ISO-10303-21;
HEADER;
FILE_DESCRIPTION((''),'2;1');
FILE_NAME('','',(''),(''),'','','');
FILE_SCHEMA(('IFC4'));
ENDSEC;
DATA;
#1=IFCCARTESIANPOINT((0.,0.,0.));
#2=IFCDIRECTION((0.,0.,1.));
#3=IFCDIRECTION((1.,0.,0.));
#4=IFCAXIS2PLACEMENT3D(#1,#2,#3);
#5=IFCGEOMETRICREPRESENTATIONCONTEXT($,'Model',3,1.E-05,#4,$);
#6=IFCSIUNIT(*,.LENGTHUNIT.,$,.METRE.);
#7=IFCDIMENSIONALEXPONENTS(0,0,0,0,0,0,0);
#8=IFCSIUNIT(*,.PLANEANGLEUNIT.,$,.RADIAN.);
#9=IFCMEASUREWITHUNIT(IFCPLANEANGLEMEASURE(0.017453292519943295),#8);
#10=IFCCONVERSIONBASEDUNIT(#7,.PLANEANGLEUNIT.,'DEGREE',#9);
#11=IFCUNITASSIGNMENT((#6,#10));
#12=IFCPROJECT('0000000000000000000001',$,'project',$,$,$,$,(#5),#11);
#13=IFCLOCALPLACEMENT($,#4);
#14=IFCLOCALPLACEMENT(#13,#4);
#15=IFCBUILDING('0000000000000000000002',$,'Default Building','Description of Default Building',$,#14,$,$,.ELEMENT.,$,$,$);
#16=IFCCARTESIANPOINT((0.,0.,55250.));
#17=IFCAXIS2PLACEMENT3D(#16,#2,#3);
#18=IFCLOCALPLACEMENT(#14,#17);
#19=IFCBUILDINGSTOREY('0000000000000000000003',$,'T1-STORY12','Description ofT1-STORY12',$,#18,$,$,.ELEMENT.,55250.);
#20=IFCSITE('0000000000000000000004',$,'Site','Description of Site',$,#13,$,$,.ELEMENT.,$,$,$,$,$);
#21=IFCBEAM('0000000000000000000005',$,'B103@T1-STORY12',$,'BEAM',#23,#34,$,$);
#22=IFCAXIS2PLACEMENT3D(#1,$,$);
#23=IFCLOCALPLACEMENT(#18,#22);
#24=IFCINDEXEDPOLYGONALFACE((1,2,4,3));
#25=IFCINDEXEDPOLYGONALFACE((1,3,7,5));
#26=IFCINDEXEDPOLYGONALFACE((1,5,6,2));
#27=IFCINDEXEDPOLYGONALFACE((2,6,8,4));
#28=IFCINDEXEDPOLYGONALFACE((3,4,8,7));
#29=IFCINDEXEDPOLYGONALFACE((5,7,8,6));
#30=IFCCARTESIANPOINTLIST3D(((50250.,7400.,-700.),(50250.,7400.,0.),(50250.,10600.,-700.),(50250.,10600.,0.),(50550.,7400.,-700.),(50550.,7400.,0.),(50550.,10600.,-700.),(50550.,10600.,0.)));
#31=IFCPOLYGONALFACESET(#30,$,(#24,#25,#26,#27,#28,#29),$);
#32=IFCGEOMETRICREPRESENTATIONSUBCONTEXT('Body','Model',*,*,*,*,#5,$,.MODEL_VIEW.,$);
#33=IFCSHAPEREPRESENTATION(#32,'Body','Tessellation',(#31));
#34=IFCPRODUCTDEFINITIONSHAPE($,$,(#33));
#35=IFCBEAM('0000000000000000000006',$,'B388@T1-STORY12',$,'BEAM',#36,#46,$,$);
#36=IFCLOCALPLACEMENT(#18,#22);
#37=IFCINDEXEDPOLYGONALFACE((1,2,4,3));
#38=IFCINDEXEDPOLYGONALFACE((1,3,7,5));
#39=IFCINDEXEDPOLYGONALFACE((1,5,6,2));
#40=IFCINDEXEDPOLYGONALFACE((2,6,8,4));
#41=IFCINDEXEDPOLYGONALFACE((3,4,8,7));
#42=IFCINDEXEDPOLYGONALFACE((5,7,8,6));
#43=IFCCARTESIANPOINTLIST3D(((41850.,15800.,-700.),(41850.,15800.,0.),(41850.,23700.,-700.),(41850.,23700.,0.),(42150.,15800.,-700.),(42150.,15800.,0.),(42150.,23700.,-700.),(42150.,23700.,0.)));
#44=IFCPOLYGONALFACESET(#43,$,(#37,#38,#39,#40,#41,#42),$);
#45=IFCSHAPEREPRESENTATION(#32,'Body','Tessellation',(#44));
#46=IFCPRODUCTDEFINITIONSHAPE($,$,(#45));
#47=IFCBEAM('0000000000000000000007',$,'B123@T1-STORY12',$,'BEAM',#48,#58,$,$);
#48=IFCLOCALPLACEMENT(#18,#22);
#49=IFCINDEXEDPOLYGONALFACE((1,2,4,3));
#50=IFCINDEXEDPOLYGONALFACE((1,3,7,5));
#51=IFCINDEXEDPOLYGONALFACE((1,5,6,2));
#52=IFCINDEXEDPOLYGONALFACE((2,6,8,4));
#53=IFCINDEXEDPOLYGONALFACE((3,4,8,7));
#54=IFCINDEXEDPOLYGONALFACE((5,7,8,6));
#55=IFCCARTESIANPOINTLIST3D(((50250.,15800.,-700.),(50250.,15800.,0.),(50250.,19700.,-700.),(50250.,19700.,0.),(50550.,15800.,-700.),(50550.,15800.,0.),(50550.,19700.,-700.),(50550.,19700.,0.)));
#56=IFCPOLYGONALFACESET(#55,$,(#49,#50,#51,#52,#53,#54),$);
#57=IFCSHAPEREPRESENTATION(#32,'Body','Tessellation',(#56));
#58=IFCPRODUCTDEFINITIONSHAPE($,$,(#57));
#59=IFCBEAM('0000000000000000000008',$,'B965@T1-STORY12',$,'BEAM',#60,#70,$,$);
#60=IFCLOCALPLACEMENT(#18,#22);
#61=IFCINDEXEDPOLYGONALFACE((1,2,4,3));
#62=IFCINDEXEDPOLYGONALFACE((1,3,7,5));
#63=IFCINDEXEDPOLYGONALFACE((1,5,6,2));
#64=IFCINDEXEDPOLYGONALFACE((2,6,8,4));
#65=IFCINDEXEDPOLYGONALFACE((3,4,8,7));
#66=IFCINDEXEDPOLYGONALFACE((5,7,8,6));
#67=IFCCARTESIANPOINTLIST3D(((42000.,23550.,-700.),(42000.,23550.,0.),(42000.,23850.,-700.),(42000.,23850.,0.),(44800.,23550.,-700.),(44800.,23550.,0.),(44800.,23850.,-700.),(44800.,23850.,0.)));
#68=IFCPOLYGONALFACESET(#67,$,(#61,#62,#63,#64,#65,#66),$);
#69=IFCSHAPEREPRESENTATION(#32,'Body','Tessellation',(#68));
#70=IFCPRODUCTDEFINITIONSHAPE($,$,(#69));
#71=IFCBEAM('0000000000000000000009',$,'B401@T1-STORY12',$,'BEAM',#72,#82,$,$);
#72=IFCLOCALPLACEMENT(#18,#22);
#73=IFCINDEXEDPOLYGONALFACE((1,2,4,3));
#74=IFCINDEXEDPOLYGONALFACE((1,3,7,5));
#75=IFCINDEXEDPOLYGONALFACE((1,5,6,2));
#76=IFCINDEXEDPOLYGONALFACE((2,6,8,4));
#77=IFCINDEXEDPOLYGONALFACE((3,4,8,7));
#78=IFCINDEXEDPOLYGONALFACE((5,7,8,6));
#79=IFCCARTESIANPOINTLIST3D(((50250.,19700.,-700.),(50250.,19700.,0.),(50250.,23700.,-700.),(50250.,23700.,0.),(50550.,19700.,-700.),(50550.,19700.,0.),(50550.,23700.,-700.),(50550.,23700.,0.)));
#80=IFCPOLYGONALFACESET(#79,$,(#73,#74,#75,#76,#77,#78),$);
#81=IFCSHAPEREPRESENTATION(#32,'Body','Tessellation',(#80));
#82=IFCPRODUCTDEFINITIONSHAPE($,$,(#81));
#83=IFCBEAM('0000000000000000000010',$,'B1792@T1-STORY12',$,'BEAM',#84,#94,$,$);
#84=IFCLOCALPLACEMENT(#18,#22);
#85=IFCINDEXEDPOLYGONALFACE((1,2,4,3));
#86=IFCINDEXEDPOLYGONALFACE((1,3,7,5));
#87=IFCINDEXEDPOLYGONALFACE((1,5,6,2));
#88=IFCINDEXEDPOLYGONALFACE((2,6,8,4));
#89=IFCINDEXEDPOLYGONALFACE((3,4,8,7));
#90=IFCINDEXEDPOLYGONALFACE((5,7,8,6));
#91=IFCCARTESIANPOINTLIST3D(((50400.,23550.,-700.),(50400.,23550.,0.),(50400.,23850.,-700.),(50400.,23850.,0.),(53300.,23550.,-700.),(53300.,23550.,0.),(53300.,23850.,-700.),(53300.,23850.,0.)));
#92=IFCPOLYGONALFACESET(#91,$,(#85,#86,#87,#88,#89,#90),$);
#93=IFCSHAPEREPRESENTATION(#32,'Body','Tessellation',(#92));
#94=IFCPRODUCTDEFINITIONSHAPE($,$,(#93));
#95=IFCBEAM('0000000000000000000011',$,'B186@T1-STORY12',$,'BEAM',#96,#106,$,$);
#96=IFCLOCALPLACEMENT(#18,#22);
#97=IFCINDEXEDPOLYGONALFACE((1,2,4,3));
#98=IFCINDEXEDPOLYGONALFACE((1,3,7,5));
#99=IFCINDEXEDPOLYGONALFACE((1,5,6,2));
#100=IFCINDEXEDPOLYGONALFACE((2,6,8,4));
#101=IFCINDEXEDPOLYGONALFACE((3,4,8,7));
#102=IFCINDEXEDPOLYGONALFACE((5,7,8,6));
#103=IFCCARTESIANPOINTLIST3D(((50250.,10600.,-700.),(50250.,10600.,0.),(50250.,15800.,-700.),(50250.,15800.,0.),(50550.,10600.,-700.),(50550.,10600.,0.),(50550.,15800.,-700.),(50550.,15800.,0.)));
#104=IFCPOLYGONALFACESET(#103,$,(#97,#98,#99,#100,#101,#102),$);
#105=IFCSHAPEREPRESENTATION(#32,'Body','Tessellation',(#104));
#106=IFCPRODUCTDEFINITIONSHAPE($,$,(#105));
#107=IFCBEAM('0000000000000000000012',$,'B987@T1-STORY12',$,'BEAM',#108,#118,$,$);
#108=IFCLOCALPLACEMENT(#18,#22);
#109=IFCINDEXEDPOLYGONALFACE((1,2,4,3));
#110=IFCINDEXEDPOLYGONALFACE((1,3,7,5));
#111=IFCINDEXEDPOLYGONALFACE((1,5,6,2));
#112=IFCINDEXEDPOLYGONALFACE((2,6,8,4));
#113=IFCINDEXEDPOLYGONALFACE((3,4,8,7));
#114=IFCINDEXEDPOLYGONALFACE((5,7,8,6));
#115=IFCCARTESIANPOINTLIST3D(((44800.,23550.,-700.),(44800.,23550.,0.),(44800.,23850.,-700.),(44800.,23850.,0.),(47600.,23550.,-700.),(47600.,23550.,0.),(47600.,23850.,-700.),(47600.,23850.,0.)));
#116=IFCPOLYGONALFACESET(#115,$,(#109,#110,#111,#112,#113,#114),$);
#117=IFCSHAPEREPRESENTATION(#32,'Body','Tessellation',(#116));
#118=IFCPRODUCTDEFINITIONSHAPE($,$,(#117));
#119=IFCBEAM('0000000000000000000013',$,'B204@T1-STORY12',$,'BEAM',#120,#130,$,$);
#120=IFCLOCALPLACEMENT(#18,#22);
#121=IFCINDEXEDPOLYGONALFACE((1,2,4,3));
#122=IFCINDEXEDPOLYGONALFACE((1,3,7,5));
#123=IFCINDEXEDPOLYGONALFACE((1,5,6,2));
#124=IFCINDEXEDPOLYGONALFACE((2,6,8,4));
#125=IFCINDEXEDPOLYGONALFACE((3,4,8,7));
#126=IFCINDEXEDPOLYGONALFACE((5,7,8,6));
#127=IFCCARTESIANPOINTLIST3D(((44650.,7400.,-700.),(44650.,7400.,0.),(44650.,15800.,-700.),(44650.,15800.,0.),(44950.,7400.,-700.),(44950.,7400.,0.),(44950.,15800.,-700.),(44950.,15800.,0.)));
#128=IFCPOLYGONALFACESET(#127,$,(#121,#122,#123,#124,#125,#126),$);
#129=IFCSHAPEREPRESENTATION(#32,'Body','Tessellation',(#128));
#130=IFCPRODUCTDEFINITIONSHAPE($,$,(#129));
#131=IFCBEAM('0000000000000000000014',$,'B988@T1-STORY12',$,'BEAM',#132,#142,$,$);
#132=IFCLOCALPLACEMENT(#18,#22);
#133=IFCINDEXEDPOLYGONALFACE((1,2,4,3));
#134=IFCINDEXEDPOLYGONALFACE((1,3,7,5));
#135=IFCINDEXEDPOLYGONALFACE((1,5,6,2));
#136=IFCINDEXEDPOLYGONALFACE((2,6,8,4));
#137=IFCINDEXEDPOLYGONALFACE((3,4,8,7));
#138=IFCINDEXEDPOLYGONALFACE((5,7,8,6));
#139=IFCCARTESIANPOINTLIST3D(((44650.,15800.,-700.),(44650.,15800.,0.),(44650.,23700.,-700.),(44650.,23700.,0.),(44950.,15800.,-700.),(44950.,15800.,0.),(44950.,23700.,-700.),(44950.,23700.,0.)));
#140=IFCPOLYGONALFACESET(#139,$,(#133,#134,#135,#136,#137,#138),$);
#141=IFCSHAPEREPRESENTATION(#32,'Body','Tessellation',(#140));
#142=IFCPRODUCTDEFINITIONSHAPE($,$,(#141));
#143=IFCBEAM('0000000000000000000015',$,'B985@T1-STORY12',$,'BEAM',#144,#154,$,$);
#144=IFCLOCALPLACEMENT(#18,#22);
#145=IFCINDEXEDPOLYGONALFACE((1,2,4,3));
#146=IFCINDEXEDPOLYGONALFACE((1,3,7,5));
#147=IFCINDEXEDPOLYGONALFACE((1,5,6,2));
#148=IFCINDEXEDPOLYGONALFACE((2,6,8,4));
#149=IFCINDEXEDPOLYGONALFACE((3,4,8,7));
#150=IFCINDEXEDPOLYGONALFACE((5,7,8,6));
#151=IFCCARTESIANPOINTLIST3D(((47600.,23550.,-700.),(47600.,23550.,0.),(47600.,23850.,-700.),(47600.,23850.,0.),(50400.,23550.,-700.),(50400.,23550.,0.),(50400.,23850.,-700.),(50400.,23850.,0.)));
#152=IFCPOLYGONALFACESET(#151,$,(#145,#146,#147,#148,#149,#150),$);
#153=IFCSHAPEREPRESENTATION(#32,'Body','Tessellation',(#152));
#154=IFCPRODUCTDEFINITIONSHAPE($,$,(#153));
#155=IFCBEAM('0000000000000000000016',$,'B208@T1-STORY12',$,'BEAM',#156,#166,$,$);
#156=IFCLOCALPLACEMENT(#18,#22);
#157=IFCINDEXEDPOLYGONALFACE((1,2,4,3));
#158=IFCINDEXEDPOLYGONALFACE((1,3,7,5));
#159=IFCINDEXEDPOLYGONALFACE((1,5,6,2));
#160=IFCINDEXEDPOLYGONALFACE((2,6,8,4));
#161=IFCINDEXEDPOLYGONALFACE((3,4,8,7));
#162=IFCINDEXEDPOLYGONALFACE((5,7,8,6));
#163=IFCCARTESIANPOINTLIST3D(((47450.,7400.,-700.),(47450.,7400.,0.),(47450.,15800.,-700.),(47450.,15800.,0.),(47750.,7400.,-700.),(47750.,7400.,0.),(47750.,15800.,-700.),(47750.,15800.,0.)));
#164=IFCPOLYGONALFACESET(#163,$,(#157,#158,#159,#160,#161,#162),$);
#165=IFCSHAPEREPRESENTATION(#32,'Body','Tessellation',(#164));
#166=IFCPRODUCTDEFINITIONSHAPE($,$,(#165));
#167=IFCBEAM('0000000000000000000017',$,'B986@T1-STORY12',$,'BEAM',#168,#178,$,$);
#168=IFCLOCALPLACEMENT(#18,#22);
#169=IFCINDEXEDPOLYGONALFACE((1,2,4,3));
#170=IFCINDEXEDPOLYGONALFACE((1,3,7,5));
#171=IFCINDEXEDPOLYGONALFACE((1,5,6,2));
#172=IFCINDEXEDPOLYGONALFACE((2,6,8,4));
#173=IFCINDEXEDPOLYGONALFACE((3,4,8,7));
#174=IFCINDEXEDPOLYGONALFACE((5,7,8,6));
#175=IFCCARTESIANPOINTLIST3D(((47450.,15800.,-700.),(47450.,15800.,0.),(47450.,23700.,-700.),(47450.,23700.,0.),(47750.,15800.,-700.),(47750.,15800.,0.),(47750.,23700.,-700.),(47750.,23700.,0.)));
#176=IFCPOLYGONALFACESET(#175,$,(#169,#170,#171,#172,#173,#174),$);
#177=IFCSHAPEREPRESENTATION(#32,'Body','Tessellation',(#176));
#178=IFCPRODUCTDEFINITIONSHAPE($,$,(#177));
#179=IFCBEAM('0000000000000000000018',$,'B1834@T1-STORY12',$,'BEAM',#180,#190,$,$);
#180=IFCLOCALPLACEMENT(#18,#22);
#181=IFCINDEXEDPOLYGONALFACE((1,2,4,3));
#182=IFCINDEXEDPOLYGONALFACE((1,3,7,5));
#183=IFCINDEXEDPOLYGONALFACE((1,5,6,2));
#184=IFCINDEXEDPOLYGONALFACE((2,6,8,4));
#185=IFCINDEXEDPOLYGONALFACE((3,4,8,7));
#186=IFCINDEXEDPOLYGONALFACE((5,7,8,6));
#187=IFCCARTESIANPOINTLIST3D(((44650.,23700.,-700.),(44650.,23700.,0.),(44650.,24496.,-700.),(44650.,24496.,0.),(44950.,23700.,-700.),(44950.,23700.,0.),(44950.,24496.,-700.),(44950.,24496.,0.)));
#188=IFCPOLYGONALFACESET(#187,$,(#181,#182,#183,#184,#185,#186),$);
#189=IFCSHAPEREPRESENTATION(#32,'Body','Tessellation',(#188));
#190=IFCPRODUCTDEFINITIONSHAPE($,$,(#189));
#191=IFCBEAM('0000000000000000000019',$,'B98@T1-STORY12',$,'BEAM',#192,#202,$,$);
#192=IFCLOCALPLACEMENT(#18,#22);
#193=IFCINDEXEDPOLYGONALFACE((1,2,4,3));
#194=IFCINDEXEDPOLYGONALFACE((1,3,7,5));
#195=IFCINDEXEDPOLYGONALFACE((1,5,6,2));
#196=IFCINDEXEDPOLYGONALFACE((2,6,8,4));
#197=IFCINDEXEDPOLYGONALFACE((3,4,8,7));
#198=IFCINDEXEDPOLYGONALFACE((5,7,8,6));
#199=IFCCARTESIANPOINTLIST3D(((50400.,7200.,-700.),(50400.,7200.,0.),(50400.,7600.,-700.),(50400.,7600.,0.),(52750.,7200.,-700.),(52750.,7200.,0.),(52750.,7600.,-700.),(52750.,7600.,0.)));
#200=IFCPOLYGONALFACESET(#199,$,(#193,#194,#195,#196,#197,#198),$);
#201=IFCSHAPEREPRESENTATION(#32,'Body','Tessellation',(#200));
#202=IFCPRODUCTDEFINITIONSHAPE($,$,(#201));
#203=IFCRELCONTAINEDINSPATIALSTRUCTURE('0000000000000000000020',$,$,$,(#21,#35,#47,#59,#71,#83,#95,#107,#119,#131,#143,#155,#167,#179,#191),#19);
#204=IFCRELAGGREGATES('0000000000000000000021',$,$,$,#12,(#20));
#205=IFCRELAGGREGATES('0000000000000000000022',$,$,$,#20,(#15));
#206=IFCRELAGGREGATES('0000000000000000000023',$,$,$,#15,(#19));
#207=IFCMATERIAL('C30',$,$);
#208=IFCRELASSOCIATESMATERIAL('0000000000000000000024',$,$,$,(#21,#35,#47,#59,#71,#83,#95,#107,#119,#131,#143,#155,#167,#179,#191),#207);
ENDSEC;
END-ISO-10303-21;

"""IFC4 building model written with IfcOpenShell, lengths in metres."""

from ifc_helpers import new_model, entity, si_unit, converted_unit, frame, origin_with_axes, place, context, subcontext, project, spatial, rectangle, extrude, material, element, save


model = new_model("IFC4")

# Units and contexts
model_context = context("Model", 3, precision=1e-05, world=origin_with_axes())
body_context = subcontext(model_context, "Body", "Model", "MODEL_VIEW")
ifc_project = project(units=[si_unit("LENGTHUNIT", "METRE"), converted_unit("PLANEANGLEUNIT", "DEGREE", entity("IfcPlaneAngleMeasure", 0.017453292519943295), si_unit("PLANEANGLEUNIT", "RADIAN"), dimensions=[0, 0, 0, 0, 0, 0, 0])], contexts=[model_context])

# Site, building, storey
site_placement = place(None, origin_with_axes())
site = spatial("IfcSite", under=ifc_project, at=site_placement, Name="Site", Description="Description of Site", CompositionType="ELEMENT")
building_placement = place(site_placement, origin_with_axes())
building = spatial("IfcBuilding", under=site, at=building_placement, Name="Default Building", Description="Description of Default Building", CompositionType="ELEMENT")
storey_placement = place(building_placement, frame((0.0, 0.0, 55250.0), z_axis=(0.0, 0.0, 1.0), x_axis=(1.0, 0.0, 0.0)))
storey = spatial("IfcBuildingStorey", under=building, at=storey_placement, Name="T1-STORY12", Description="Description ofT1-STORY12", CompositionType="ELEMENT", Elevation=55250.0)

# Beams
ifc_material_1 = material(Name="C30")
beam_1_placement = place(storey_placement, frame((50400.0, 7400.0, -350.0), z_axis=(0.0, 1.0, 0.0), x_axis=(-1.0, 0.0, 0.0)))
element("IfcBeam", 1, at=beam_1_placement, inside=storey, material=ifc_material_1, Name="B103@T1-STORY12", ObjectType="BEAM", context=body_context, shape_type="SweptSolid", body=[
    extrude(rectangle(XDim=300.0, YDim=700.0), origin_with_axes(), (0.0, 0.0, 1.0), 3200.0),
])
beam_2_placement = place(storey_placement, frame((42000.0, 15800.0, -350.0), z_axis=(0.0, 1.0, 0.0), x_axis=(-1.0, 0.0, 0.0)))
element("IfcBeam", 2, at=beam_2_placement, inside=storey, material=ifc_material_1, Name="B388@T1-STORY12", ObjectType="BEAM", context=body_context, shape_type="SweptSolid", body=[
    extrude(rectangle(XDim=300.0, YDim=700.0), origin_with_axes(), (0.0, 0.0, 1.0), 7900.0),
])
beam_3_placement = place(storey_placement, frame((50400.0, 15800.0, -350.0), z_axis=(0.0, 1.0, 0.0), x_axis=(-1.0, 0.0, 0.0)))
element("IfcBeam", 3, at=beam_3_placement, inside=storey, material=ifc_material_1, Name="B123@T1-STORY12", ObjectType="BEAM", context=body_context, shape_type="SweptSolid", body=[
    extrude(rectangle(XDim=300.0, YDim=700.0), origin_with_axes(), (0.0, 0.0, 1.0), 3900.0),
])
beam_4_placement = place(storey_placement, frame((42000.0, 23700.0, -350.0), z_axis=(1.0, 0.0, 0.0), x_axis=(0.0, 1.0, 0.0)))
element("IfcBeam", 4, at=beam_4_placement, inside=storey, material=ifc_material_1, Name="B965@T1-STORY12", ObjectType="BEAM", context=body_context, shape_type="SweptSolid", body=[
    extrude(rectangle(XDim=300.0, YDim=700.0), origin_with_axes(), (0.0, 0.0, 1.0), 2800.0),
])
beam_5_placement = place(storey_placement, frame((50400.0, 19700.0, -350.0), z_axis=(0.0, 1.0, 0.0), x_axis=(-1.0, 0.0, 0.0)))
element("IfcBeam", 5, at=beam_5_placement, inside=storey, material=ifc_material_1, Name="B401@T1-STORY12", ObjectType="BEAM", context=body_context, shape_type="SweptSolid", body=[
    extrude(rectangle(XDim=300.0, YDim=700.0), origin_with_axes(), (0.0, 0.0, 1.0), 4000.0),
])
beam_6_placement = place(storey_placement, frame((50400.0, 23700.0, -350.0), z_axis=(1.0, 0.0, 0.0), x_axis=(0.0, 1.0, 0.0)))
element("IfcBeam", 6, at=beam_6_placement, inside=storey, material=ifc_material_1, Name="B1792@T1-STORY12", ObjectType="BEAM", context=body_context, shape_type="SweptSolid", body=[
    extrude(rectangle(XDim=300.0, YDim=700.0), origin_with_axes(), (0.0, 0.0, 1.0), 2900.0),
])
beam_7_placement = place(storey_placement, frame((50400.0, 10600.0, -350.0), z_axis=(0.0, 1.0, 0.0), x_axis=(-1.0, 0.0, 0.0)))
element("IfcBeam", 7, at=beam_7_placement, inside=storey, material=ifc_material_1, Name="B186@T1-STORY12", ObjectType="BEAM", context=body_context, shape_type="SweptSolid", body=[
    extrude(rectangle(XDim=300.0, YDim=700.0), origin_with_axes(), (0.0, 0.0, 1.0), 5200.0),
])
beam_8_placement = place(storey_placement, frame((44800.0, 23700.0, -350.0), z_axis=(1.0, 0.0, 0.0), x_axis=(0.0, 1.0, 0.0)))
element("IfcBeam", 8, at=beam_8_placement, inside=storey, material=ifc_material_1, Name="B987@T1-STORY12", ObjectType="BEAM", context=body_context, shape_type="SweptSolid", body=[
    extrude(rectangle(XDim=300.0, YDim=700.0), origin_with_axes(), (0.0, 0.0, 1.0), 2800.0),
])
beam_9_placement = place(storey_placement, frame((44800.0, 7400.0, -350.0), z_axis=(0.0, 1.0, 0.0), x_axis=(-1.0, 0.0, 0.0)))
element("IfcBeam", 9, at=beam_9_placement, inside=storey, material=ifc_material_1, Name="B204@T1-STORY12", ObjectType="BEAM", context=body_context, shape_type="SweptSolid", body=[
    extrude(rectangle(XDim=300.0, YDim=700.0), origin_with_axes(), (0.0, 0.0, 1.0), 8400.0),
])
beam_10_placement = place(storey_placement, frame((44800.0, 15800.0, -350.0), z_axis=(0.0, 1.0, 0.0), x_axis=(-1.0, 0.0, 0.0)))
element("IfcBeam", 10, at=beam_10_placement, inside=storey, material=ifc_material_1, Name="B988@T1-STORY12", ObjectType="BEAM", context=body_context, shape_type="SweptSolid", body=[
    extrude(rectangle(XDim=300.0, YDim=700.0), origin_with_axes(), (0.0, 0.0, 1.0), 7900.0),
])
beam_11_placement = place(storey_placement, frame((47600.0, 23700.0, -350.0), z_axis=(1.0, 0.0, 0.0), x_axis=(0.0, 1.0, 0.0)))
element("IfcBeam", 11, at=beam_11_placement, inside=storey, material=ifc_material_1, Name="B985@T1-STORY12", ObjectType="BEAM", context=body_context, shape_type="SweptSolid", body=[
    extrude(rectangle(XDim=300.0, YDim=700.0), origin_with_axes(), (0.0, 0.0, 1.0), 2800.0),
])
beam_12_placement = place(storey_placement, frame((47600.0, 7400.0, -350.0), z_axis=(0.0, 1.0, 0.0), x_axis=(-1.0, 0.0, 0.0)))
element("IfcBeam", 12, at=beam_12_placement, inside=storey, material=ifc_material_1, Name="B208@T1-STORY12", ObjectType="BEAM", context=body_context, shape_type="SweptSolid", body=[
    extrude(rectangle(XDim=300.0, YDim=700.0), origin_with_axes(), (0.0, 0.0, 1.0), 8400.0),
])
beam_13_placement = place(storey_placement, frame((47600.0, 15800.0, -350.0), z_axis=(0.0, 1.0, 0.0), x_axis=(-1.0, 0.0, 0.0)))
element("IfcBeam", 13, at=beam_13_placement, inside=storey, material=ifc_material_1, Name="B986@T1-STORY12", ObjectType="BEAM", context=body_context, shape_type="SweptSolid", body=[
    extrude(rectangle(XDim=300.0, YDim=700.0), origin_with_axes(), (0.0, 0.0, 1.0), 7900.0),
])
beam_14_placement = place(storey_placement, frame((44800.0, 23700.0, -350.0), z_axis=(0.0, 1.0, 0.0), x_axis=(-1.0, 0.0, 0.0)))
element("IfcBeam", 14, at=beam_14_placement, inside=storey, material=ifc_material_1, Name="B1834@T1-STORY12", ObjectType="BEAM", context=body_context, shape_type="SweptSolid", body=[
    extrude(rectangle(XDim=300.0, YDim=700.0), origin_with_axes(), (0.0, 0.0, 1.0), 796.0),
])
beam_15_placement = place(storey_placement, frame((50400.0, 7400.0, -350.0), z_axis=(1.0, 0.0, 0.0), x_axis=(0.0, 1.0, 0.0)))
element("IfcBeam", 15, at=beam_15_placement, inside=storey, material=ifc_material_1, Name="B98@T1-STORY12", ObjectType="BEAM", context=body_context, shape_type="SweptSolid", body=[
    extrude(rectangle(XDim=400.0, YDim=700.0), origin_with_axes(), (0.0, 0.0, 1.0), 2350.0),
])

save(model, "model.ifc")
